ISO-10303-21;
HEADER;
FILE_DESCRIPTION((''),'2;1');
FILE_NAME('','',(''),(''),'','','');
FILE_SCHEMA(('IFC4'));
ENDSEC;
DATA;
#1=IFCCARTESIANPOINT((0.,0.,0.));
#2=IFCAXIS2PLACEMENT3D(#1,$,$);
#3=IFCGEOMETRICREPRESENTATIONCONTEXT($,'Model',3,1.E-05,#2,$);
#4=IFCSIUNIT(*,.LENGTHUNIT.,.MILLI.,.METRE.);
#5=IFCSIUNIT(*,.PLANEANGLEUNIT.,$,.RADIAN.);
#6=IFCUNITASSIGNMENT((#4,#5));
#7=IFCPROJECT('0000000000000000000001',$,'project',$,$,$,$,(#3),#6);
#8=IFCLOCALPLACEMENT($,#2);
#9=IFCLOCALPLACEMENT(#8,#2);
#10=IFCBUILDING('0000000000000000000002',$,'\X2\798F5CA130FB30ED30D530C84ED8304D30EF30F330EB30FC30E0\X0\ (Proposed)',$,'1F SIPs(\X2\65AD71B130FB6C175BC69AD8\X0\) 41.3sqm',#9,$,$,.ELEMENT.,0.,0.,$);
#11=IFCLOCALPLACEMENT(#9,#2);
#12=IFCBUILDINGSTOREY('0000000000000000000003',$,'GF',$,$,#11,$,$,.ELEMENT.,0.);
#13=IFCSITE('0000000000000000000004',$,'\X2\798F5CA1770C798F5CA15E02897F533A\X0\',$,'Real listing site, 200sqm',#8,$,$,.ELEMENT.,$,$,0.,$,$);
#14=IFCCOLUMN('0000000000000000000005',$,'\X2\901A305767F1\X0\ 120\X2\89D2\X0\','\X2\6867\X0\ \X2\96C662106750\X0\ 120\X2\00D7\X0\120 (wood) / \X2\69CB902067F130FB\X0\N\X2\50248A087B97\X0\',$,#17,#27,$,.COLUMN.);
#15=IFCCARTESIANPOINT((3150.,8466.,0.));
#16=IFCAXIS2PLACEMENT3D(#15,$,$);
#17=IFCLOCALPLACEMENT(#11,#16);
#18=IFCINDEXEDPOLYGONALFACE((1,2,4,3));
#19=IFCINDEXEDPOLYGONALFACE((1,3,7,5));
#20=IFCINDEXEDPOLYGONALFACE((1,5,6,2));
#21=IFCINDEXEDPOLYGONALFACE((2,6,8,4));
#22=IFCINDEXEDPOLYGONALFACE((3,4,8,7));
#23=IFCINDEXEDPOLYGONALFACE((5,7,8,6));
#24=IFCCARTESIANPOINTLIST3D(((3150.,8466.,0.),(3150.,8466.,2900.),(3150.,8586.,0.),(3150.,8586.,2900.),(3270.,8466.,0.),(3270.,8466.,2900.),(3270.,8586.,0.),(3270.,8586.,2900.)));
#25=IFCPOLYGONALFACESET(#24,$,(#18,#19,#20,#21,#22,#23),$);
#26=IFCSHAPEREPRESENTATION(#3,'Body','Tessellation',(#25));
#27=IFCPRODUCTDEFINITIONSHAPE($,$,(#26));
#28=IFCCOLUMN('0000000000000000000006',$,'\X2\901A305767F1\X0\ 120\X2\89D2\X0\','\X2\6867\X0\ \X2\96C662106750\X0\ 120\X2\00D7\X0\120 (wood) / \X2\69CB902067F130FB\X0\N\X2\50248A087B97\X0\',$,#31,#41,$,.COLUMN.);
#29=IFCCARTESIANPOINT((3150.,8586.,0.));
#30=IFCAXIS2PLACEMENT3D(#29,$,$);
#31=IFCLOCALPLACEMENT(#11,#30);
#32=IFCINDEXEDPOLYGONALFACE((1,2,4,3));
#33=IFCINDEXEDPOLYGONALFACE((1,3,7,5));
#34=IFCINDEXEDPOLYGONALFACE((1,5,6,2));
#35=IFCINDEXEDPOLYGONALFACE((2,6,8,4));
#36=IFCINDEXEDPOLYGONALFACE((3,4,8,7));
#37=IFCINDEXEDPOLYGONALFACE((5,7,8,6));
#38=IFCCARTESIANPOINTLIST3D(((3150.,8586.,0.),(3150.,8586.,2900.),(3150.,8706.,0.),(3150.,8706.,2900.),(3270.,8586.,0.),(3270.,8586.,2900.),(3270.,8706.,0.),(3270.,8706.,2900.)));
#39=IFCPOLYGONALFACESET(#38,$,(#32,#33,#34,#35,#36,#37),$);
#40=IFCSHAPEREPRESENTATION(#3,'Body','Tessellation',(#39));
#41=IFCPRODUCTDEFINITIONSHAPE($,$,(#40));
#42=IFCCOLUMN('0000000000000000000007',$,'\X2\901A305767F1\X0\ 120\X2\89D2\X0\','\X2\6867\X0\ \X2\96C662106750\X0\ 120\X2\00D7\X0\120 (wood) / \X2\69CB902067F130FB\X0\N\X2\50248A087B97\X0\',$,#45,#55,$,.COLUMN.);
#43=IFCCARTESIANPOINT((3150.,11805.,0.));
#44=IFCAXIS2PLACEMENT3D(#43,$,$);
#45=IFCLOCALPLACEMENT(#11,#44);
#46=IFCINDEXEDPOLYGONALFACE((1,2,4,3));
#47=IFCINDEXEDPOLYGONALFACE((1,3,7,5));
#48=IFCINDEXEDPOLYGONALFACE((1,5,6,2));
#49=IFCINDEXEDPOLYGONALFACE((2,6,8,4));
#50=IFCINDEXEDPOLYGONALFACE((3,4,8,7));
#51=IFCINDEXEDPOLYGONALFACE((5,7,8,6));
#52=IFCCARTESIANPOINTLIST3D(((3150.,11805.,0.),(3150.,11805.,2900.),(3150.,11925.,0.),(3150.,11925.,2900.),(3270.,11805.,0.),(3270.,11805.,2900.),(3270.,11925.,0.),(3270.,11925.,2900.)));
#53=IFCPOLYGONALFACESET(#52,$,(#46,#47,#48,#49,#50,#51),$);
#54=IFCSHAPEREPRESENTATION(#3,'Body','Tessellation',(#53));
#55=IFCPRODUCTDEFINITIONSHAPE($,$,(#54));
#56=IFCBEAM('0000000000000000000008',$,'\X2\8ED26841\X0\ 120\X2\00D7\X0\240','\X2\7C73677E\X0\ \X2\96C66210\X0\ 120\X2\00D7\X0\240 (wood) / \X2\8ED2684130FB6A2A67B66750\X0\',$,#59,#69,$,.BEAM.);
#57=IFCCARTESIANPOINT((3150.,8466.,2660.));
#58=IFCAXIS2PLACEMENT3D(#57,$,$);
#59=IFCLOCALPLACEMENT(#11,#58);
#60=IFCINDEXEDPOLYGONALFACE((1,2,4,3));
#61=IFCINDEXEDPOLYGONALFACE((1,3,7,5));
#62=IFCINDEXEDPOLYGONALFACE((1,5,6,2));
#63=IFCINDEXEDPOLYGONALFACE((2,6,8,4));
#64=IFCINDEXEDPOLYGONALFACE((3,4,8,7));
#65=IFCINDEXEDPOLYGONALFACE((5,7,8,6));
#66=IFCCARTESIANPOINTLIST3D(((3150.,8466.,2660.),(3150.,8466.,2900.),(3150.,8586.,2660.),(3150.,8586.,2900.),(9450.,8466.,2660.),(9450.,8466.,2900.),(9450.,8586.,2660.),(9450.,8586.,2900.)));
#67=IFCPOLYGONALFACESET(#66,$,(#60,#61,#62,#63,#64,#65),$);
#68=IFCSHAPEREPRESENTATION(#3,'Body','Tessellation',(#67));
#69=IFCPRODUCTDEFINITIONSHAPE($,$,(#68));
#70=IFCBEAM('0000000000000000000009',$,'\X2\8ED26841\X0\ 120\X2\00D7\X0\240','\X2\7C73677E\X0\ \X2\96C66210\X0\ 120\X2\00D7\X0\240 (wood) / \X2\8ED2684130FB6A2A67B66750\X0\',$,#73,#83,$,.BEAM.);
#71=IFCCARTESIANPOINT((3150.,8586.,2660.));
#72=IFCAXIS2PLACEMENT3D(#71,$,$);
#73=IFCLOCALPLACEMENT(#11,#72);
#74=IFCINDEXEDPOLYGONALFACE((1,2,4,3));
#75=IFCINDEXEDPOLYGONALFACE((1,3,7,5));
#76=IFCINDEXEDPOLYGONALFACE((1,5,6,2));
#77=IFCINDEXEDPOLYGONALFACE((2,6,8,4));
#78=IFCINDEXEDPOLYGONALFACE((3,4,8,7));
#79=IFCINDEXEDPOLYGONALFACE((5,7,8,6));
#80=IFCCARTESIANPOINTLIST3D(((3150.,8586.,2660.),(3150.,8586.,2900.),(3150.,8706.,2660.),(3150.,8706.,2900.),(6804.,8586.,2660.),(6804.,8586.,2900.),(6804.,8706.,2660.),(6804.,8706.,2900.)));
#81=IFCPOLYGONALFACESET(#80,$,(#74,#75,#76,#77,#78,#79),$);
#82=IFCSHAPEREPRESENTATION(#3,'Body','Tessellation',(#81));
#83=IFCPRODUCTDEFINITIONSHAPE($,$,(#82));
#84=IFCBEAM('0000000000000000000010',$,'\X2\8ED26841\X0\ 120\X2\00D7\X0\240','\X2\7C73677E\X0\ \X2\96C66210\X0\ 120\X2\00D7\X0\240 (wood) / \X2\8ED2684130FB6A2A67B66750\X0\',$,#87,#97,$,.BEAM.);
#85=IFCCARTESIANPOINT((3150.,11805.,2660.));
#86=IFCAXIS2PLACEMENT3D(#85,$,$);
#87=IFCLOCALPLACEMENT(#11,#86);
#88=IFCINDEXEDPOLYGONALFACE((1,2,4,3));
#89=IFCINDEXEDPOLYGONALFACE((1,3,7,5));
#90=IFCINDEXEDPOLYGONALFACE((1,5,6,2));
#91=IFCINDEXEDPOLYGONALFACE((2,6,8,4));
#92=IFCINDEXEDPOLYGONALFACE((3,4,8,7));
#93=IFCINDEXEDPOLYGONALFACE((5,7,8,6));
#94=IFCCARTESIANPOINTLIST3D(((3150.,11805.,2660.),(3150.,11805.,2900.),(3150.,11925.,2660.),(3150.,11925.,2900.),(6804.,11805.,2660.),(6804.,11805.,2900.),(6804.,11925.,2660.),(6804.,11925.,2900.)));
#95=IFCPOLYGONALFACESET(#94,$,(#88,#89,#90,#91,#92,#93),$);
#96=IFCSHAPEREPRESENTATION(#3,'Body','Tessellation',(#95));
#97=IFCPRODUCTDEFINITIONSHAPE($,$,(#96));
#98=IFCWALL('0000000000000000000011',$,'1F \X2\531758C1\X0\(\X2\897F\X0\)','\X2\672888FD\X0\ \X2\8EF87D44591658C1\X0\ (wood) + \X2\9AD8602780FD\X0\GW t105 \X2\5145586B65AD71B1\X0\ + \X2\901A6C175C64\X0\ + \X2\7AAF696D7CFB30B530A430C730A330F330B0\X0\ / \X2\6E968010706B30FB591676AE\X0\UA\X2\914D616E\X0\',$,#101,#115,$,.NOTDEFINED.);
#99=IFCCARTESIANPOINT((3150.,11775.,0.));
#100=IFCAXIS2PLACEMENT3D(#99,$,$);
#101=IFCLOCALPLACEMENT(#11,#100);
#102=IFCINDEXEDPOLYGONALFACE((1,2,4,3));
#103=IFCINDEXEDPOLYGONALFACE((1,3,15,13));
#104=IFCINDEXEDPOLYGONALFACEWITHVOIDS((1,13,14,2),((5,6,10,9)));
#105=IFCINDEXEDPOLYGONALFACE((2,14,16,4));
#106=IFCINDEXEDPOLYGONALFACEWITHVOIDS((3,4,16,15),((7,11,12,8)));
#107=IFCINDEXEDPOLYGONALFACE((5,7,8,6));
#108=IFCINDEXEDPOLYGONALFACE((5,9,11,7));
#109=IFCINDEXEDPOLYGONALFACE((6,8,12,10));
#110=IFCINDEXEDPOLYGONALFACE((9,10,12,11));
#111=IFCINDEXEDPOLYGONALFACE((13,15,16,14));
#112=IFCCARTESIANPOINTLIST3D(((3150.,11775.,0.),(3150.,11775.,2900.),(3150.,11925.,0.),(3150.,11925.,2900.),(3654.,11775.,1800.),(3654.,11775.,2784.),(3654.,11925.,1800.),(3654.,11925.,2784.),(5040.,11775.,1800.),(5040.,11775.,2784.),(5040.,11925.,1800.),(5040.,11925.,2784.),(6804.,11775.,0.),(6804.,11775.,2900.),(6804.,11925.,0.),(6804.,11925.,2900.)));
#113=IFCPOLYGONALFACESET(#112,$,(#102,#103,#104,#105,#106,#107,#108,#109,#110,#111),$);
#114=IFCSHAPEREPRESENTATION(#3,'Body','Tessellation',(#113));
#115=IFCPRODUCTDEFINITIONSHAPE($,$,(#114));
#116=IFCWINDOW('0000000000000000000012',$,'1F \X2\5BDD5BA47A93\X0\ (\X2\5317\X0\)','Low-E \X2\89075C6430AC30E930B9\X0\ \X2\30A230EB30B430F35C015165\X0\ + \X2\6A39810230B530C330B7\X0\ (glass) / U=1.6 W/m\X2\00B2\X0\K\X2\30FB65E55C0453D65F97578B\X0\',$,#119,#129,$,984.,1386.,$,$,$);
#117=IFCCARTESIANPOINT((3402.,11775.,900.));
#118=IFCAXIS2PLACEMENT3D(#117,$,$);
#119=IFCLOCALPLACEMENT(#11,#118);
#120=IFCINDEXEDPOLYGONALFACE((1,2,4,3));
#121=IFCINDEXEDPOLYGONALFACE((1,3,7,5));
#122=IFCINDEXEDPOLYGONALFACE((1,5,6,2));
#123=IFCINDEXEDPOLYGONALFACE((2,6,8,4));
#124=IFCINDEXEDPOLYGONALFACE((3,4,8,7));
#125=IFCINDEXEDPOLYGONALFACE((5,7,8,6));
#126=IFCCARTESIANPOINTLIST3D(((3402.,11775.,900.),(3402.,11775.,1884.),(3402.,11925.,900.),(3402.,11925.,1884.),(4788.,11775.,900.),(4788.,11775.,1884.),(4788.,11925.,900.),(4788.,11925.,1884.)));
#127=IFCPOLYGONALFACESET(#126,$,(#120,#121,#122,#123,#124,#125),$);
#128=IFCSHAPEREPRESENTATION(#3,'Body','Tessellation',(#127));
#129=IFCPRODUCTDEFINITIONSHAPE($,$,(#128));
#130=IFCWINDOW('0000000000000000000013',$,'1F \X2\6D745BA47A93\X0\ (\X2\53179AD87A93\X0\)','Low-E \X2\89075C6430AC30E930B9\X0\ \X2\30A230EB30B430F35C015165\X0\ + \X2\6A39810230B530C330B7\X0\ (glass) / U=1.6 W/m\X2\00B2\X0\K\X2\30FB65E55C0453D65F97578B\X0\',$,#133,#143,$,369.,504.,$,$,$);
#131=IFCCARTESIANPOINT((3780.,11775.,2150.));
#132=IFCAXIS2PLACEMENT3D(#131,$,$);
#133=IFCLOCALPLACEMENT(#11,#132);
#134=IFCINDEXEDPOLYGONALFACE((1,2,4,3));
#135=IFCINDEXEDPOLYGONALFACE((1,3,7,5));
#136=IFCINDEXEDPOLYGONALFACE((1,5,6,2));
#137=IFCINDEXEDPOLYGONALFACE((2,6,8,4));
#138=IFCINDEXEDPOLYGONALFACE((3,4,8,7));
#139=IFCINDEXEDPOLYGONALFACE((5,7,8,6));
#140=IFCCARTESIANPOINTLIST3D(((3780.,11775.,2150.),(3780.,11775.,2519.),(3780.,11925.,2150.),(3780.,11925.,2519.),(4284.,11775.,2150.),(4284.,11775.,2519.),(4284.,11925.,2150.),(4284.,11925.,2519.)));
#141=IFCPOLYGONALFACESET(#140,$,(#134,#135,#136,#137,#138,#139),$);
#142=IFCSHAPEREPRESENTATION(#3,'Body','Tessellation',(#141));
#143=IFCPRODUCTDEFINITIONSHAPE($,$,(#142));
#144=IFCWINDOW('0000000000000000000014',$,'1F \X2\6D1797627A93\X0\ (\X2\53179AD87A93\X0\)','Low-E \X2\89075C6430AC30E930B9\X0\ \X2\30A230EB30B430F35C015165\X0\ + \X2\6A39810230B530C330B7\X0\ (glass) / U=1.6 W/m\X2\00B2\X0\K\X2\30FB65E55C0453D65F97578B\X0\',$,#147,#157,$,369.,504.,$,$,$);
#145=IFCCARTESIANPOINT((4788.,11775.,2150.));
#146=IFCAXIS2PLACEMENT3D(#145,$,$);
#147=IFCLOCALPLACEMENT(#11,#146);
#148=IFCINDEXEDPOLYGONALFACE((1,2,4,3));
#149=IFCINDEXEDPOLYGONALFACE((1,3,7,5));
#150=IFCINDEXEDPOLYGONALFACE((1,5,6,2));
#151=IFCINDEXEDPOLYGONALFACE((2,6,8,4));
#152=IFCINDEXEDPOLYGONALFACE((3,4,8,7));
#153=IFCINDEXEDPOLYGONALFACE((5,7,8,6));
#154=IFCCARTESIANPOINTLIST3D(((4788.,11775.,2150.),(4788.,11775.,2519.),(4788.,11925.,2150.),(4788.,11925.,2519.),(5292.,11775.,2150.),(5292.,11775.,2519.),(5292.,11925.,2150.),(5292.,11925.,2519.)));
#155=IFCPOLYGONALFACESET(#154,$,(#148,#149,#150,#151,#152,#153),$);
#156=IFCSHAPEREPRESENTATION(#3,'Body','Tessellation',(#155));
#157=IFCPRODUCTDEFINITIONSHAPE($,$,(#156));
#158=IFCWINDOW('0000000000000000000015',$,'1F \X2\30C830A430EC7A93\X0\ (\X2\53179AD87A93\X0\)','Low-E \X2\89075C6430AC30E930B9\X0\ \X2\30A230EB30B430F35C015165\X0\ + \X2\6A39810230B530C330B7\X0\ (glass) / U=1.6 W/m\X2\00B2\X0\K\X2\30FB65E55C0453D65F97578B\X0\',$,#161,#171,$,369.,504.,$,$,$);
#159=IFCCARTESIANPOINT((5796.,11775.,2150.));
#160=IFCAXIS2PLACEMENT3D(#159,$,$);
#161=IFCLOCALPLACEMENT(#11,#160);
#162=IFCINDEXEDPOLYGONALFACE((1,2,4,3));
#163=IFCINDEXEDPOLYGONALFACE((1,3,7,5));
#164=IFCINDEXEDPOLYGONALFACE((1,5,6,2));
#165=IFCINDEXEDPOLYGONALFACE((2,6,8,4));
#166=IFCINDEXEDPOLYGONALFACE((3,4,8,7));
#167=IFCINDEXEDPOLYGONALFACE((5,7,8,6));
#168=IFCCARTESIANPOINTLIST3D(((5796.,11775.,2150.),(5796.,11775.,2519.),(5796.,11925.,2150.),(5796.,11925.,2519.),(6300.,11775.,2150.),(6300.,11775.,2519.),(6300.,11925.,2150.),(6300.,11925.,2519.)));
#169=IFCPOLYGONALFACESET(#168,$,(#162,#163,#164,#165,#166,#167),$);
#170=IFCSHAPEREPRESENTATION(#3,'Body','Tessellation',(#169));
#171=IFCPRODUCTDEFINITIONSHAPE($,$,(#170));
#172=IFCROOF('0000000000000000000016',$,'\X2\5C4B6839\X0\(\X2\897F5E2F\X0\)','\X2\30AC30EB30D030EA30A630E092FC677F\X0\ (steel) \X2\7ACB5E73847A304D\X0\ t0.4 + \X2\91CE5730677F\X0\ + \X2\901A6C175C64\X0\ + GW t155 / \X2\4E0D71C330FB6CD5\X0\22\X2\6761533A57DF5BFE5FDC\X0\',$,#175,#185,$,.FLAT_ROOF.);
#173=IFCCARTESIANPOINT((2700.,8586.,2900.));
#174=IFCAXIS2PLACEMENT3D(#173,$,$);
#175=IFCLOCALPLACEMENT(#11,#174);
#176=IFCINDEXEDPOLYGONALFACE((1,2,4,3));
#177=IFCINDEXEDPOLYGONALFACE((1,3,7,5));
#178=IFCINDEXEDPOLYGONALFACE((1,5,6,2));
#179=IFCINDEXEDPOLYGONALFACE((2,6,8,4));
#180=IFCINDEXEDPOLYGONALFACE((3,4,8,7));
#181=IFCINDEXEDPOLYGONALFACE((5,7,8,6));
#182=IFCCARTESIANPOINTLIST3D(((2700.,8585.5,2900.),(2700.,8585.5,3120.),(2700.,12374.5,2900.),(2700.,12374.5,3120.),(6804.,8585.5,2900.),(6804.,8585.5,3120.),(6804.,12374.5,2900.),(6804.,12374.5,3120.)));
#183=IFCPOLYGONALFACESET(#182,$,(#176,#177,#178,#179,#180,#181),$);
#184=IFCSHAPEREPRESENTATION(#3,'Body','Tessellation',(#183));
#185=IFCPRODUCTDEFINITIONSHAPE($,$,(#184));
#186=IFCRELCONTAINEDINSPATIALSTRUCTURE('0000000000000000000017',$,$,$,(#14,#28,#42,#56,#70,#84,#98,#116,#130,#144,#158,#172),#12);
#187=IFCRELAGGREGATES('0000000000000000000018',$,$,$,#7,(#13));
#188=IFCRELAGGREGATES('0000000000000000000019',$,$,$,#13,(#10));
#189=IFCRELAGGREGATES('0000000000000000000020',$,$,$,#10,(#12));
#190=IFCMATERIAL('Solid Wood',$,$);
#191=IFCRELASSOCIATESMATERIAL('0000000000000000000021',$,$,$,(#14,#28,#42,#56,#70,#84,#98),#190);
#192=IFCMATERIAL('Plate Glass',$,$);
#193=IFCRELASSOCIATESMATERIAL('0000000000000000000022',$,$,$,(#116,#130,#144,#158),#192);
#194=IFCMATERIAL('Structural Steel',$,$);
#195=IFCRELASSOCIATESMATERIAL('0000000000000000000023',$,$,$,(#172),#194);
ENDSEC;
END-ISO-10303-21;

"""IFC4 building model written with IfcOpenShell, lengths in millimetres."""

from ifc_helpers import new_model, si_unit, frame, frame_2d, origin, place, context, project, spatial, rectangle, extrude, material, element, fill, save


model = new_model("IFC4")

# Units and contexts
model_context = context("Model", 3, precision=1e-05, world=origin())
ifc_project = project(units=[si_unit("LENGTHUNIT", "METRE", prefix="MILLI"), si_unit("PLANEANGLEUNIT", "RADIAN")], contexts=[model_context])

# Site, building, storey
site_placement = place(None, origin())
site = spatial("IfcSite", under=ifc_project, at=site_placement, Name="福岡県福岡市西区", ObjectType="Real listing site, 200sqm", CompositionType="ELEMENT", RefElevation=0.0)
building_placement = place(site_placement, origin())
building = spatial("IfcBuilding", under=site, at=building_placement, Name="福岡・ロフト付きワンルーム (Proposed)", ObjectType="1F SIPs(断熱・気密高) 41.3sqm", CompositionType="ELEMENT", ElevationOfRefHeight=0.0, ElevationOfTerrain=0.0)
storey_placement = place(building_placement, origin())
storey = spatial("IfcBuildingStorey", under=building, at=storey_placement, Name="GF", CompositionType="ELEMENT", Elevation=0.0)

# Columns
ifc_material_1 = material(Name="Solid Wood")
column_1_placement = place(storey_placement, frame((3150.0, 8466.0, 0.0)))
element("IfcColumn", 1, at=column_1_placement, inside=storey, material=ifc_material_1, Name="通し柱 120角", Description="桧 集成材 120×120 (wood) / 構造柱・N値計算", PredefinedType="COLUMN", context=model_context, shape_type="SweptSolid", body=[
    extrude(rectangle(XDim=120.0, YDim=120.0, at=frame_2d((60.0, 60.0))), frame((3150.0, 8466.0, 0.0)), (0.0, 0.0, 1.0), 2900.0),
])
column_2_placement = place(storey_placement, frame((3150.0, 8586.0, 0.0)))
element("IfcColumn", 2, at=column_2_placement, inside=storey, material=ifc_material_1, Name="通し柱 120角", Description="桧 集成材 120×120 (wood) / 構造柱・N値計算", PredefinedType="COLUMN", context=model_context, shape_type="SweptSolid", body=[
    extrude(rectangle(XDim=120.0, YDim=120.0, at=frame_2d((60.0, 60.0))), frame((3150.0, 8586.0, 0.0)), (0.0, 0.0, 1.0), 2900.0),
])
column_3_placement = place(storey_placement, frame((3150.0, 11805.0, 0.0)))
element("IfcColumn", 3, at=column_3_placement, inside=storey, material=ifc_material_1, Name="通し柱 120角", Description="桧 集成材 120×120 (wood) / 構造柱・N値計算", PredefinedType="COLUMN", context=model_context, shape_type="SweptSolid", body=[
    extrude(rectangle(XDim=120.0, YDim=120.0, at=frame_2d((60.0, 60.0))), frame((3150.0, 11805.0, 0.0)), (0.0, 0.0, 1.0), 2900.0),
])

# Beams
beam_1_placement = place(storey_placement, frame((3150.0, 8466.0, 2660.0)))
element("IfcBeam", 4, at=beam_1_placement, inside=storey, material=ifc_material_1, Name="軒桁 120×240", Description="米松 集成 120×240 (wood) / 軒桁・横架材", PredefinedType="BEAM", context=model_context, shape_type="SweptSolid", body=[
    extrude(rectangle(XDim=6300.0, YDim=120.0, at=frame_2d((3150.0, 60.0))), frame((3150.0, 8466.0, 2660.0)), (0.0, 0.0, 1.0), 240.0),
])
beam_2_placement = place(storey_placement, frame((3150.0, 8586.0, 2660.0)))
element("IfcBeam", 5, at=beam_2_placement, inside=storey, material=ifc_material_1, Name="軒桁 120×240", Description="米松 集成 120×240 (wood) / 軒桁・横架材", PredefinedType="BEAM", context=model_context, shape_type="SweptSolid", body=[
    extrude(rectangle(XDim=3654.0, YDim=120.0, at=frame_2d((1827.0, 60.0))), frame((3150.0, 8586.0, 2660.0)), (0.0, 0.0, 1.0), 240.0),
])
beam_3_placement = place(storey_placement, frame((3150.0, 11805.0, 2660.0)))
element("IfcBeam", 6, at=beam_3_placement, inside=storey, material=ifc_material_1, Name="軒桁 120×240", Description="米松 集成 120×240 (wood) / 軒桁・横架材", PredefinedType="BEAM", context=model_context, shape_type="SweptSolid", body=[
    extrude(rectangle(XDim=3654.0, YDim=120.0, at=frame_2d((1827.0, 60.0))), frame((3150.0, 11805.0, 2660.0)), (0.0, 0.0, 1.0), 240.0),
])

# Wall, openings, windows
wall_1_placement = place(storey_placement, frame((3150.0, 11775.0, 0.0)))
wall_1 = element("IfcWall", 7, at=wall_1_placement, inside=storey, material=ifc_material_1, Name="1F 北壁(西)", Description="木製 軸組外壁 (wood) + 高性能GW t105 充填断熱 + 通気層 + 窯業系サイディング / 準耐火・外皮UA配慮", PredefinedType="NOTDEFINED", context=model_context, shape_type="SweptSolid", body=[
    extrude(rectangle(XDim=3654.0, YDim=150.0, at=frame_2d((1827.0, 75.0))), frame((3150.0, 11775.0, 0.0)), (0.0, 0.0, 1.0), 2900.0),
])
opening_1_placement = place(storey_placement, frame((3402.0, 11775.0, 900.0)))
opening_1 = element("IfcOpeningElement", 8, at=opening_1_placement, cuts=wall_1, PredefinedType="NOTDEFINED", context=model_context, shape_type="SweptSolid", body=[
    extrude(rectangle(XDim=1386.0, YDim=150.0, at=frame_2d((693.0, 75.0))), frame((3402.0, 11775.0, 900.0)), (0.0, 0.0, 1.0), 984.0),
])
opening_2_placement = place(storey_placement, frame((3780.0, 11775.0, 2150.0)))
opening_2 = element("IfcOpeningElement", 9, at=opening_2_placement, cuts=wall_1, PredefinedType="NOTDEFINED", context=model_context, shape_type="SweptSolid", body=[
    extrude(rectangle(XDim=504.0, YDim=150.0, at=frame_2d((252.0, 75.0))), frame((3780.0, 11775.0, 2150.0)), (0.0, 0.0, 1.0), 369.0),
])
opening_3_placement = place(storey_placement, frame((4788.0, 11775.0, 2150.0)))
opening_3 = element("IfcOpeningElement", 10, at=opening_3_placement, cuts=wall_1, PredefinedType="NOTDEFINED", context=model_context, shape_type="SweptSolid", body=[
    extrude(rectangle(XDim=504.0, YDim=150.0, at=frame_2d((252.0, 75.0))), frame((4788.0, 11775.0, 2150.0)), (0.0, 0.0, 1.0), 369.0),
])
opening_4_placement = place(storey_placement, frame((5796.0, 11775.0, 2150.0)))
opening_4 = element("IfcOpeningElement", 11, at=opening_4_placement, cuts=wall_1, PredefinedType="NOTDEFINED", context=model_context, shape_type="SweptSolid", body=[
    extrude(rectangle(XDim=504.0, YDim=150.0, at=frame_2d((252.0, 75.0))), frame((5796.0, 11775.0, 2150.0)), (0.0, 0.0, 1.0), 369.0),
])
ifc_material_2 = material(Name="Plate Glass")
window_1_placement = place(storey_placement, frame((3402.0, 11775.0, 900.0)))
window_1 = element("IfcWindow", 12, at=window_1_placement, inside=storey, material=ifc_material_2, Name="1F 寝室窓 (北)", Description="Low-E 複層ガラス アルゴン封入 + 樹脂サッシ (glass) / U=1.6 W/m²K・日射取得型", OverallHeight=984.0, OverallWidth=1386.0, context=model_context, shape_type="SweptSolid", body=[
    extrude(rectangle(XDim=1386.0, YDim=150.0, at=frame_2d((693.0, 75.0))), frame((3402.0, 11775.0, 900.0)), (0.0, 0.0, 1.0), 984.0),
])
fill(opening_1, window_1)
window_2_placement = place(storey_placement, frame((3780.0, 11775.0, 2150.0)))
window_2 = element("IfcWindow", 13, at=window_2_placement, inside=storey, material=ifc_material_2, Name="1F 浴室窓 (北高窓)", Description="Low-E 複層ガラス アルゴン封入 + 樹脂サッシ (glass) / U=1.6 W/m²K・日射取得型", OverallHeight=369.0, OverallWidth=504.0, context=model_context, shape_type="SweptSolid", body=[
    extrude(rectangle(XDim=504.0, YDim=150.0, at=frame_2d((252.0, 75.0))), frame((3780.0, 11775.0, 2150.0)), (0.0, 0.0, 1.0), 369.0),
])
fill(opening_2, window_2)
window_3_placement = place(storey_placement, frame((4788.0, 11775.0, 2150.0)))
window_3 = element("IfcWindow", 14, at=window_3_placement, inside=storey, material=ifc_material_2, Name="1F 洗面窓 (北高窓)", Description="Low-E 複層ガラス アルゴン封入 + 樹脂サッシ (glass) / U=1.6 W/m²K・日射取得型", OverallHeight=369.0, OverallWidth=504.0, context=model_context, shape_type="SweptSolid", body=[
    extrude(rectangle(XDim=504.0, YDim=150.0, at=frame_2d((252.0, 75.0))), frame((4788.0, 11775.0, 2150.0)), (0.0, 0.0, 1.0), 369.0),
])
fill(opening_3, window_3)
window_4_placement = place(storey_placement, frame((5796.0, 11775.0, 2150.0)))
window_4 = element("IfcWindow", 15, at=window_4_placement, inside=storey, material=ifc_material_2, Name="1F トイレ窓 (北高窓)", Description="Low-E 複層ガラス アルゴン封入 + 樹脂サッシ (glass) / U=1.6 W/m²K・日射取得型", OverallHeight=369.0, OverallWidth=504.0, context=model_context, shape_type="SweptSolid", body=[
    extrude(rectangle(XDim=504.0, YDim=150.0, at=frame_2d((252.0, 75.0))), frame((5796.0, 11775.0, 2150.0)), (0.0, 0.0, 1.0), 369.0),
])
fill(opening_4, window_4)

# Roof
ifc_material_3 = material(Name="Structural Steel")
roof_placement = place(storey_placement, frame((2700.0, 8586.0, 2900.0)))
element("IfcRoof", 16, at=roof_placement, inside=storey, material=ifc_material_3, Name="屋根(西帯)", Description="ガルバリウム鋼板 (steel) 立平葺き t0.4 + 野地板 + 通気層 + GW t155 / 不燃・法22条区域対応", PredefinedType="FLAT_ROOF", context=model_context, shape_type="SweptSolid", body=[
    extrude(rectangle(XDim=4104.0, YDim=3789.0, at=frame_2d((2052.0, 1894.0))), frame((2700.0, 8586.0, 2900.0)), (0.0, 0.0, 1.0), 220.0),
])

save(model, "model.ifc")
